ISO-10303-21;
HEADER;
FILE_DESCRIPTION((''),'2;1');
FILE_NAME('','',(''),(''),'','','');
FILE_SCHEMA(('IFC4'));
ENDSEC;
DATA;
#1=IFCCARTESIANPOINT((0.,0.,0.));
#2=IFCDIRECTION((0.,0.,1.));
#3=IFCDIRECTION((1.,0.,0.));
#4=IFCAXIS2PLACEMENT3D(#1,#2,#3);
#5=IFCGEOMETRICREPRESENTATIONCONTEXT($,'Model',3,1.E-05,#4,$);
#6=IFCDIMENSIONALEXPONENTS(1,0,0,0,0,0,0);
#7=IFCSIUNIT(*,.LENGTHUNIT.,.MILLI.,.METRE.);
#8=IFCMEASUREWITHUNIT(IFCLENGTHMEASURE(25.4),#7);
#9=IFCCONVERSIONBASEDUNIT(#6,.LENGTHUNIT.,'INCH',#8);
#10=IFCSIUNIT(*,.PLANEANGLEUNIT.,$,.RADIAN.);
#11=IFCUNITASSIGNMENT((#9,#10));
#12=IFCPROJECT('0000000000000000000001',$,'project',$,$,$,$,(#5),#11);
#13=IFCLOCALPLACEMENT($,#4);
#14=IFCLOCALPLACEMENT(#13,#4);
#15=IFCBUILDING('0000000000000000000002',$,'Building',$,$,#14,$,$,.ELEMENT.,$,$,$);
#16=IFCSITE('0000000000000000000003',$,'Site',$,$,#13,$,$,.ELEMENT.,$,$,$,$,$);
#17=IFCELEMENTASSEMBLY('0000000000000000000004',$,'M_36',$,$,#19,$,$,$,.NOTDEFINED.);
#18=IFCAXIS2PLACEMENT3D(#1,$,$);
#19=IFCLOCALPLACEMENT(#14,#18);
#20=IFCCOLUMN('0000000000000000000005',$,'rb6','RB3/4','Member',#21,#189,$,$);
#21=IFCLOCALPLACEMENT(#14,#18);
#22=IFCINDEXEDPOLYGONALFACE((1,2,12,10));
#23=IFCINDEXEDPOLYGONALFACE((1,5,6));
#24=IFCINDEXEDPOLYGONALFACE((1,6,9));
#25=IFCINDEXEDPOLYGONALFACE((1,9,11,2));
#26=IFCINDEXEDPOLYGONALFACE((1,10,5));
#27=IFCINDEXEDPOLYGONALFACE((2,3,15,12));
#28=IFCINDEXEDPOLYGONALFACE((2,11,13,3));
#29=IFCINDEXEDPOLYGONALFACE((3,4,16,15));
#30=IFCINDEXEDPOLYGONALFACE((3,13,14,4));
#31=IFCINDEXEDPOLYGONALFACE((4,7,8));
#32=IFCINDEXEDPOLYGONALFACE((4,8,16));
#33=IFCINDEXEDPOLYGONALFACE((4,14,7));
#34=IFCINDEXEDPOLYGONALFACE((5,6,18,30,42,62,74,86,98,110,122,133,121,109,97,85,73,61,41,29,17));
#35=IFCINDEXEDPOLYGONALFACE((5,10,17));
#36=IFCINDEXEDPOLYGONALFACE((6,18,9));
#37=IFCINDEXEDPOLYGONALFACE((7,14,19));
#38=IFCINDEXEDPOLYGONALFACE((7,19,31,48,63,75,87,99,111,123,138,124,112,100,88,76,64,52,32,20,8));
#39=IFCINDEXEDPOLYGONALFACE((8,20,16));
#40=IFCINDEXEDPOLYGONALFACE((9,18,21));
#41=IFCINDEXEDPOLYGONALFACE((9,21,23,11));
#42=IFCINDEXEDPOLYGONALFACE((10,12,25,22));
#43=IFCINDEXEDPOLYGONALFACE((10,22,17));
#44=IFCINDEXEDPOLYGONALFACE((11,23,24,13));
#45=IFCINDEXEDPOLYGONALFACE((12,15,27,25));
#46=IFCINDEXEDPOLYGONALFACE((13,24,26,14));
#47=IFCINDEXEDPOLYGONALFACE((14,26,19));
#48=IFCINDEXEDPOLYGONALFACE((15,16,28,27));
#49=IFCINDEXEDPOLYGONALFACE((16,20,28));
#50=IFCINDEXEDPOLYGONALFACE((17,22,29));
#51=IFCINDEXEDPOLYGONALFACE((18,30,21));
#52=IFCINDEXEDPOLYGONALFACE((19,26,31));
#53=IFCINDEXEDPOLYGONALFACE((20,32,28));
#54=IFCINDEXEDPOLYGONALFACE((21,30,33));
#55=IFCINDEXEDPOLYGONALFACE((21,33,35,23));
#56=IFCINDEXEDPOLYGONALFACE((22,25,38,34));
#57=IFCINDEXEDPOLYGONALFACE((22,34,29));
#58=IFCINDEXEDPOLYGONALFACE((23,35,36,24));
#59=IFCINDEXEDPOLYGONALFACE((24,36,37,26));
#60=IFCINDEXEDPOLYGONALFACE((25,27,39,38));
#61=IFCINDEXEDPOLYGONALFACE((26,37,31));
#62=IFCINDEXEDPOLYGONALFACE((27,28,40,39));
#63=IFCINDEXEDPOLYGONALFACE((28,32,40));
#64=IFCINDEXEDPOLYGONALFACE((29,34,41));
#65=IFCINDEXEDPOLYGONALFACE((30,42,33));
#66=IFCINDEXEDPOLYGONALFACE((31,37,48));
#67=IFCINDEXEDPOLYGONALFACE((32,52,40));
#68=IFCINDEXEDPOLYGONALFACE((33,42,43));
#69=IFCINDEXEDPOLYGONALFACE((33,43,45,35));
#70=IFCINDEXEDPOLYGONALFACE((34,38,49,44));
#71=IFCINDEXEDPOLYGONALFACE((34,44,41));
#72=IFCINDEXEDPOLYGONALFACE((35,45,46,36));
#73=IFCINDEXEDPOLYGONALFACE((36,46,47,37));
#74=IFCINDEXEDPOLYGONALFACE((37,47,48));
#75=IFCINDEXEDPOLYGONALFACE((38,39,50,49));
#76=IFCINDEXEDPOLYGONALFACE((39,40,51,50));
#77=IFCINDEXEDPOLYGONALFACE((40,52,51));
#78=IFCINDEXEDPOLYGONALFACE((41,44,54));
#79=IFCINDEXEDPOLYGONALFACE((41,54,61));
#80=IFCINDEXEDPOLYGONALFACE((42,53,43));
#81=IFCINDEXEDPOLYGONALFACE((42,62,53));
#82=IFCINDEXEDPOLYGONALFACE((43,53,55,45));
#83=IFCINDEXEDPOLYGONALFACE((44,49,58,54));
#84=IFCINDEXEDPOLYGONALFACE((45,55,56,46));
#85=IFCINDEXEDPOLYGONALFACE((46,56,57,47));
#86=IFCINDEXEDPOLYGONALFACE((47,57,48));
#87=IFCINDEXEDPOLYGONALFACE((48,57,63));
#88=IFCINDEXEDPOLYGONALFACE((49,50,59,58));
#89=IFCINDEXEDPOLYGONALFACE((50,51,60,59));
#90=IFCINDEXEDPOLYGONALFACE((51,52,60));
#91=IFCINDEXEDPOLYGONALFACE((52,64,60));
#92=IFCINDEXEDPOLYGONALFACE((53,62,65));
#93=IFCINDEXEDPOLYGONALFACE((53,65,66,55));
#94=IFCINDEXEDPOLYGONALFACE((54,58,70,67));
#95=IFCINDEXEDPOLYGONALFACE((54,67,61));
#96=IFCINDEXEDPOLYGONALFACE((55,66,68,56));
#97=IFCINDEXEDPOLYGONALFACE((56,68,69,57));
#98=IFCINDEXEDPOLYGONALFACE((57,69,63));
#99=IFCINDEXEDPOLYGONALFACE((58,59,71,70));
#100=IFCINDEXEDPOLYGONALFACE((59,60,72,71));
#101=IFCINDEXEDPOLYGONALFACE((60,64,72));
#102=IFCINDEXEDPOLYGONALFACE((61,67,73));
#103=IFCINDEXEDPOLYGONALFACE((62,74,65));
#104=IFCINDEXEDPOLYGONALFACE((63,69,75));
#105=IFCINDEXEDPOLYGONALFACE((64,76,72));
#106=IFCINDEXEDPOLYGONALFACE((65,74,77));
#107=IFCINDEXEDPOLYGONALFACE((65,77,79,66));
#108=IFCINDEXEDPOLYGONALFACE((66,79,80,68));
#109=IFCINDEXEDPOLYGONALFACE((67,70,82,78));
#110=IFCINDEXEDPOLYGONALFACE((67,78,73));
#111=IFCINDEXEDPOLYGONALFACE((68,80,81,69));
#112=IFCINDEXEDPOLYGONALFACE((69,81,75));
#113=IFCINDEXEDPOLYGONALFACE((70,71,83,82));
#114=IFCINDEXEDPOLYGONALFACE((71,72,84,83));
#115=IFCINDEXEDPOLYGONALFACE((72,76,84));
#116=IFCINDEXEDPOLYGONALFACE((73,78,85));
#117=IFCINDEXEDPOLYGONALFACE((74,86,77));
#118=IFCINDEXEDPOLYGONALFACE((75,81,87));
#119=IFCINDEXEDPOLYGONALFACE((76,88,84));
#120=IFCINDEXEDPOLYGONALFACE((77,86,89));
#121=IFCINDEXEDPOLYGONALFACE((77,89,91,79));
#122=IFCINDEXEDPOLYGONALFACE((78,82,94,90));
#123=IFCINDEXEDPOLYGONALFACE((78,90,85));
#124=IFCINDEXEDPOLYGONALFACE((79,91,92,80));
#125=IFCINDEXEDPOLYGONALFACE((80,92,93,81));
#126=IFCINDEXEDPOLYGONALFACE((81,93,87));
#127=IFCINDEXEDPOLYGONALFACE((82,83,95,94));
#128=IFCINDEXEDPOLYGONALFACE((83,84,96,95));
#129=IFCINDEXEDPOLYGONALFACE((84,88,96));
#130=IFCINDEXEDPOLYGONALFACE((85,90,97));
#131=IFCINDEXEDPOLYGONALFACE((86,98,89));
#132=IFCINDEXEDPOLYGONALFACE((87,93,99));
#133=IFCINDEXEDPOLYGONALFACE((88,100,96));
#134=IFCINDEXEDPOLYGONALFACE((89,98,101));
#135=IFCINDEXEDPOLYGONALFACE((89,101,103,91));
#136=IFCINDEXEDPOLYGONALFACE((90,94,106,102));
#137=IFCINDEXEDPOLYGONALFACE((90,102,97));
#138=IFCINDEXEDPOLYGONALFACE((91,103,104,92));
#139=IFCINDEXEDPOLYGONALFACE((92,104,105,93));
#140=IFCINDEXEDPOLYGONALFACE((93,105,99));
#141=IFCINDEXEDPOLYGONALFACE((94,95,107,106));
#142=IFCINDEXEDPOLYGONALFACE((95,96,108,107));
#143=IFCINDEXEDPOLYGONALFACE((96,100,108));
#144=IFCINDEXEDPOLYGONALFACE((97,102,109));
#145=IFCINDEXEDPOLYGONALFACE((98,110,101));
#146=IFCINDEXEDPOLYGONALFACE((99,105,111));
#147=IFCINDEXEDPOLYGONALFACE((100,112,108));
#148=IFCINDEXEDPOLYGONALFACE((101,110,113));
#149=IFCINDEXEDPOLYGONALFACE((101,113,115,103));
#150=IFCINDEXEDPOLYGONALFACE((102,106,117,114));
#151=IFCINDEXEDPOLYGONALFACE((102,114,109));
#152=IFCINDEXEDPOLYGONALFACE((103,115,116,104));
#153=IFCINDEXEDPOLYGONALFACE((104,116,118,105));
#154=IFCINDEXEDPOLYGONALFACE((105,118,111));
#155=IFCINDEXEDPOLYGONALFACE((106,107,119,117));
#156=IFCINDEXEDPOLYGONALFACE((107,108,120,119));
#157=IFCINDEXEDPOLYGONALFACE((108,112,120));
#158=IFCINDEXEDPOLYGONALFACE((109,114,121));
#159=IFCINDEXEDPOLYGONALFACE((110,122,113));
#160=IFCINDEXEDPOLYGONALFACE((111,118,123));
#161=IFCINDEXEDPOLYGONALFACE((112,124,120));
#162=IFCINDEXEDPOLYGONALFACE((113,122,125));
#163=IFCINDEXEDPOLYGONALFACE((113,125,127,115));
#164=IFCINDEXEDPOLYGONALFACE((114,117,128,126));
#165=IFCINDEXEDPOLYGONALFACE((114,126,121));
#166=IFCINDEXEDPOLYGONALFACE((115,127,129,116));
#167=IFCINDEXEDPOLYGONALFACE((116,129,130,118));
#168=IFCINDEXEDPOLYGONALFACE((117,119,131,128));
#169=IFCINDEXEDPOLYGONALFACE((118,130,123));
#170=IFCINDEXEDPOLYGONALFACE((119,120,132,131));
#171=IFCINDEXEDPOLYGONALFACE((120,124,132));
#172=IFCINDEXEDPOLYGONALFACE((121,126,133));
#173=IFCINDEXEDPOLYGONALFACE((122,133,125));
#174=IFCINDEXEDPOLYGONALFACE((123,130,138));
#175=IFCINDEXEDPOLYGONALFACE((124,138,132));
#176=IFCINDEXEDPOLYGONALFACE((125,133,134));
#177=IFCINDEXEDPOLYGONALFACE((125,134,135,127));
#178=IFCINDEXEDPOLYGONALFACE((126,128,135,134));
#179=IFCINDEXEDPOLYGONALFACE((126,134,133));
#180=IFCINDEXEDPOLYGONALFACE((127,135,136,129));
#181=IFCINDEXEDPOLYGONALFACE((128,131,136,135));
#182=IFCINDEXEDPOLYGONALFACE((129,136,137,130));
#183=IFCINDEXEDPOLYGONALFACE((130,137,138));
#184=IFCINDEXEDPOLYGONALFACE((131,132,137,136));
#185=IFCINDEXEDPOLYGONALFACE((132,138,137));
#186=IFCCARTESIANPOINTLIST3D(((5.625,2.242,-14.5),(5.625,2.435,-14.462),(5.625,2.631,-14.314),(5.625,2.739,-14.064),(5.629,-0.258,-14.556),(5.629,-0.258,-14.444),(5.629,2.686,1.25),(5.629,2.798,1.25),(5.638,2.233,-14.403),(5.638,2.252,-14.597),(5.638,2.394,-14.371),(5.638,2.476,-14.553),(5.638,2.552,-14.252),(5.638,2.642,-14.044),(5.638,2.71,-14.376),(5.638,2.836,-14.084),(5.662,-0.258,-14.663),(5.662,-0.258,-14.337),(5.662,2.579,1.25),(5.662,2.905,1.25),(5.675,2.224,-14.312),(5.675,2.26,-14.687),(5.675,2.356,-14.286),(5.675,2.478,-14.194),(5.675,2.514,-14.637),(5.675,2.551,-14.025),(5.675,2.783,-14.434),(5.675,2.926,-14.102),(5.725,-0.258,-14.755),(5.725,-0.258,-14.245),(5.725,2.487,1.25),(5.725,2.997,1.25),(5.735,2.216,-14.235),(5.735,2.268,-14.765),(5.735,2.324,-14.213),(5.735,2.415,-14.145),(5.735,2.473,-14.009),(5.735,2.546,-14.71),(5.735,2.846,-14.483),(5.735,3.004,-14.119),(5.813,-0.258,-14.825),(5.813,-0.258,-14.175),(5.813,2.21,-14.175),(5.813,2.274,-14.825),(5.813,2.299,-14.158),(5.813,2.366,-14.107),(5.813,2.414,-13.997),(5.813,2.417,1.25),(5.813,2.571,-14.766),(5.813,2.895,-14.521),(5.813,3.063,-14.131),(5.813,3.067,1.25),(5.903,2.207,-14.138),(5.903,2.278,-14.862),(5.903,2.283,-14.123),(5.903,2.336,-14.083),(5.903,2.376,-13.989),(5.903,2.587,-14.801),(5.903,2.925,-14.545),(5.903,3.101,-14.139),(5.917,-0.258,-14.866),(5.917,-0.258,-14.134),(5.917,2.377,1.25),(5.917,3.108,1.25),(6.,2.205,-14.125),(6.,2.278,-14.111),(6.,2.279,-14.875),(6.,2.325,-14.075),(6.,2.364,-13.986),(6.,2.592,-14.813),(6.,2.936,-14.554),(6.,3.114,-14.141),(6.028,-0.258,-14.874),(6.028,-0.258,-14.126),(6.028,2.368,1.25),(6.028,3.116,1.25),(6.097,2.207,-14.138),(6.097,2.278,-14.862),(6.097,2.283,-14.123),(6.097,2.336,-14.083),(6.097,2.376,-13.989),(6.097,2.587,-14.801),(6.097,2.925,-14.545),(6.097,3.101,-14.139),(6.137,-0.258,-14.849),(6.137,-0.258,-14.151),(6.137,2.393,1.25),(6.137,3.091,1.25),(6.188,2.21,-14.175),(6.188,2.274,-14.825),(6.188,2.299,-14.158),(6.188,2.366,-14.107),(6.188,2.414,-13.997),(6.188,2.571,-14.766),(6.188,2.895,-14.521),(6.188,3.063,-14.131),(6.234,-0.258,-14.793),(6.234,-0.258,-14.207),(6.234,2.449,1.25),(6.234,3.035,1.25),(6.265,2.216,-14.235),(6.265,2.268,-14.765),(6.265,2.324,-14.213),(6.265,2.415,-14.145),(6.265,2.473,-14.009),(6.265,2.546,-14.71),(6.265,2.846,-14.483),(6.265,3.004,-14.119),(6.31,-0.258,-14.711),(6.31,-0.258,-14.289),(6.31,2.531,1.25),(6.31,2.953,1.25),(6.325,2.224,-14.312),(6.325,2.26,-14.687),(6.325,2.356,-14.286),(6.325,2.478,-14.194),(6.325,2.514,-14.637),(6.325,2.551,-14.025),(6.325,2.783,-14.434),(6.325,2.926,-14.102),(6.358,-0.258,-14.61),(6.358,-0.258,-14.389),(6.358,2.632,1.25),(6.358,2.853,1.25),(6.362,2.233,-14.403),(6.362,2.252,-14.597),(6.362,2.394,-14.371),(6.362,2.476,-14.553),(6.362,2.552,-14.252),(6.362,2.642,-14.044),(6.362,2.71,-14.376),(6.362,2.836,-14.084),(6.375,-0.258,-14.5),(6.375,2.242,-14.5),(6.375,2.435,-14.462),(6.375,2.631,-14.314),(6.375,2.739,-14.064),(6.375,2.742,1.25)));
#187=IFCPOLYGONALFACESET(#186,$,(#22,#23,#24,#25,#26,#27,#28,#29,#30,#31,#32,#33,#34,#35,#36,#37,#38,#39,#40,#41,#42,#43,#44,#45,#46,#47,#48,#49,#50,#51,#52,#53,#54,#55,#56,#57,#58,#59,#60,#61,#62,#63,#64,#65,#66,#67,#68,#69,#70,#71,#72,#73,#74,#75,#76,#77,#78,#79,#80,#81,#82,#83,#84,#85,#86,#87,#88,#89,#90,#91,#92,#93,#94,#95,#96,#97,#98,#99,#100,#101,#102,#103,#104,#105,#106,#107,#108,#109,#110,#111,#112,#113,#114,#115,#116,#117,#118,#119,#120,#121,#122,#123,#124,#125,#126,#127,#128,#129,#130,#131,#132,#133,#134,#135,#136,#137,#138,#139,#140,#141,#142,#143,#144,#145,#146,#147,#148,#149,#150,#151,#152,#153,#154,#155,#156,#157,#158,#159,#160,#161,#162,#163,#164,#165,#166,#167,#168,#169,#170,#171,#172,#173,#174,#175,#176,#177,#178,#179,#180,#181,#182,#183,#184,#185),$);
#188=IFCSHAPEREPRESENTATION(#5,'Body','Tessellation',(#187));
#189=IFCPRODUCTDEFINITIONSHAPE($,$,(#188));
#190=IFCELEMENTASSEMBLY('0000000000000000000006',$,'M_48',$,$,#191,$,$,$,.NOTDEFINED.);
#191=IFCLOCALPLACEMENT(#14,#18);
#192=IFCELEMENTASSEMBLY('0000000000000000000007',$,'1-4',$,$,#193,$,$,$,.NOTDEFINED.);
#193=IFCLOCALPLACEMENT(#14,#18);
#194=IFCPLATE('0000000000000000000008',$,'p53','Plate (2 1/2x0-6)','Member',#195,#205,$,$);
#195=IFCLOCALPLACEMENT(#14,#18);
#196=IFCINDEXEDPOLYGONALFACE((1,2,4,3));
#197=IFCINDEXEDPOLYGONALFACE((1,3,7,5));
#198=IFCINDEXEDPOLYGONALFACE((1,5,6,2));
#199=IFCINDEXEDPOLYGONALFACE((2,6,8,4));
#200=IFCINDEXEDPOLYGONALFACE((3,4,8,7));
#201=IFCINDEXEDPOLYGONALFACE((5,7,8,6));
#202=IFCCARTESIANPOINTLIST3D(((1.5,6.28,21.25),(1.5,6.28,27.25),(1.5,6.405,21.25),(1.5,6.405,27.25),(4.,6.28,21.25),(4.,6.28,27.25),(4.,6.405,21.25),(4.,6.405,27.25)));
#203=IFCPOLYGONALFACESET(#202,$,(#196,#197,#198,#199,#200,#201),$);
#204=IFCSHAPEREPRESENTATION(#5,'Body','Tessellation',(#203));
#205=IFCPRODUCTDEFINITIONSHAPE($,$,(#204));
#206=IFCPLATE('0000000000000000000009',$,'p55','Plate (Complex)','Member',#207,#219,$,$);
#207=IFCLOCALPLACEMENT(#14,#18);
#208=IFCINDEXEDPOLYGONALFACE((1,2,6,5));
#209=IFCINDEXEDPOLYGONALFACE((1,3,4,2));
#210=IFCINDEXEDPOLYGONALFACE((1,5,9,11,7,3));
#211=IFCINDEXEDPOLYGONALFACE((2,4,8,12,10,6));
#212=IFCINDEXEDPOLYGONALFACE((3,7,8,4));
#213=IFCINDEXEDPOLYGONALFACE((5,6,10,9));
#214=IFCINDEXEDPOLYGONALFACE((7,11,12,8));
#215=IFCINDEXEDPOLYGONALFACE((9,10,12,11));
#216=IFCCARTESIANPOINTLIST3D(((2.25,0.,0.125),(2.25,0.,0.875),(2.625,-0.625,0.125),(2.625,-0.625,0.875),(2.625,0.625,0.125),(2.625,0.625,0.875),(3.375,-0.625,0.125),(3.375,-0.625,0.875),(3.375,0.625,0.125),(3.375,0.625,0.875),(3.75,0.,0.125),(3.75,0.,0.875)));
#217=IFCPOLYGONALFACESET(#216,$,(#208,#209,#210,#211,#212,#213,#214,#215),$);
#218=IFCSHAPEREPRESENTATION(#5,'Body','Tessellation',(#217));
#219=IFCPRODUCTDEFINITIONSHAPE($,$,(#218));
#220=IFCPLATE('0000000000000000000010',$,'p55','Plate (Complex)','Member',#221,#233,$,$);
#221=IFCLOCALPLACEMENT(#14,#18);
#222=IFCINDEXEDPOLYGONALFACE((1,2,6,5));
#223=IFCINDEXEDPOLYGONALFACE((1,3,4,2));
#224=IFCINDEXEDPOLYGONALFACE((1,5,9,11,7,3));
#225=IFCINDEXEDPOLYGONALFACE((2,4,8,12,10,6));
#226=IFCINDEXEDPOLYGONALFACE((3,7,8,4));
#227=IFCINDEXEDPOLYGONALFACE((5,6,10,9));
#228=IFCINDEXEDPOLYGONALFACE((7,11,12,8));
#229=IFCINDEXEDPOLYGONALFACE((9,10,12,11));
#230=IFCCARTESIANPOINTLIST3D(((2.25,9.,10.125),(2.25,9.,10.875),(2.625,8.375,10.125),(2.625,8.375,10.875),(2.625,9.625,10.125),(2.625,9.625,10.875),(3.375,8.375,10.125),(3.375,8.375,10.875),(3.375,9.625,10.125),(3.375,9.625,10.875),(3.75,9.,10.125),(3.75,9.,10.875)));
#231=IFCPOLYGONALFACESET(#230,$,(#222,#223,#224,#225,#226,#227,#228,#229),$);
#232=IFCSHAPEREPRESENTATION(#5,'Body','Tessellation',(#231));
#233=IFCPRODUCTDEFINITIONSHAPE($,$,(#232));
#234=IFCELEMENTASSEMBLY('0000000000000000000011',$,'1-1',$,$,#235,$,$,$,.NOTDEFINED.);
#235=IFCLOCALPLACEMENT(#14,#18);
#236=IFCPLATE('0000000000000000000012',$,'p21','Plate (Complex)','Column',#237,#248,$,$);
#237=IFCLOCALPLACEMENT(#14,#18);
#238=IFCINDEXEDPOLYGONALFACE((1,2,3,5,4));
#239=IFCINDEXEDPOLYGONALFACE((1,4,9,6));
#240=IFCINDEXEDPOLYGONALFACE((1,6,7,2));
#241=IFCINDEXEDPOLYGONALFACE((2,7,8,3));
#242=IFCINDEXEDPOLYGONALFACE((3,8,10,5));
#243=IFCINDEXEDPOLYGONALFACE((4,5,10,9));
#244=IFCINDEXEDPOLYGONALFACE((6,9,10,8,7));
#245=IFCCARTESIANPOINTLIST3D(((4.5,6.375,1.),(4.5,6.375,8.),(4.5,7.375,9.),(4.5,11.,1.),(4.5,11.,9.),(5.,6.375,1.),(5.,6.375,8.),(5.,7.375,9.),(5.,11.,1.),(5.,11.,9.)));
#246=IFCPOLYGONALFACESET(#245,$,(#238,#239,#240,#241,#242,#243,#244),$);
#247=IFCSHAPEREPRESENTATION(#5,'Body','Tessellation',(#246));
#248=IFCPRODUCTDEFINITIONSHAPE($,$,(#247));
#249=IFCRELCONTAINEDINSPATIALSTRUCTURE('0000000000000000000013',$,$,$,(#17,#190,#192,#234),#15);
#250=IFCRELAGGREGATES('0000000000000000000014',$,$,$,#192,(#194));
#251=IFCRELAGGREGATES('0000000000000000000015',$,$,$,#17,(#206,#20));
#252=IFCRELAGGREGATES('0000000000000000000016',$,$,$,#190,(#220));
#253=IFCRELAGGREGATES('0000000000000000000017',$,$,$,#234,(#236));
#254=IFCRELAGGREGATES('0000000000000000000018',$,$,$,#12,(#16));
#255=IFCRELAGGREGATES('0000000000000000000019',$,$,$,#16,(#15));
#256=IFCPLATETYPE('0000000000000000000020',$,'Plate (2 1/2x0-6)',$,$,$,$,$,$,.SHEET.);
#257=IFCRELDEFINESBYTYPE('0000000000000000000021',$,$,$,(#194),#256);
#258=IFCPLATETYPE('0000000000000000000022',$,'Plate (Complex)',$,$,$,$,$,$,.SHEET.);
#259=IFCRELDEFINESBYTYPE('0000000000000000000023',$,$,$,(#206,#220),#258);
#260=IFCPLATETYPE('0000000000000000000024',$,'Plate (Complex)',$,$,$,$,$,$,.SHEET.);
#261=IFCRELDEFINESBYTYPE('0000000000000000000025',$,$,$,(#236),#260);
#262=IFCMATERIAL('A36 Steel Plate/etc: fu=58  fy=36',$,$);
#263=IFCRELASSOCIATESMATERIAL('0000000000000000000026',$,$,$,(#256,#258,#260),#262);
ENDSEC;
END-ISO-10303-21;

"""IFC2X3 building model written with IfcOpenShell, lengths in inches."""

from ifc_helpers import new_model, entity, si_unit, converted_unit, frame, origin_with_axes, place, context, project, spatial, polyline, outline, extrude, source, transform, mapped, material, type_object, type_shapes, element, aggregate, save


model = new_model("IFC2X3")

# Units and contexts
model_context = context("Model", 3, precision=1e-05, world=origin_with_axes())
ifc_project = project(units=[converted_unit("LENGTHUNIT", "INCH", entity("IfcLengthMeasure", 25.4), si_unit("LENGTHUNIT", "METRE", prefix="MILLI"), dimensions=[1, 0, 0, 0, 0, 0, 0]), si_unit("PLANEANGLEUNIT", "RADIAN")], contexts=[model_context])

# Site, building
site_placement = place(None, origin_with_axes())
site = spatial("IfcSite", under=ifc_project, at=site_placement, Name="Site", CompositionType="ELEMENT")
building_placement = place(site_placement, origin_with_axes())
building = spatial("IfcBuilding", under=site, at=building_placement, Name="Building", CompositionType="ELEMENT")

# Element assemblies, column
assembly_1_placement = place(building_placement, frame((3.0, 0.0, -22.668), z_axis=(0.0, -1.0, 0.0), x_axis=(0.0, 0.0, 1.0)))
assembly_1 = element("IfcElementAssembly", 1, at=assembly_1_placement, inside=building, Name="M_36", PredefinedType="NOTDEFINED")
column_1_placement = place(assembly_1_placement, frame((8.44, -3.0, 0.258), z_axis=(0.0, -1.0, 0.0), x_axis=(-1.0, 0.0, 0.0)))
cartesian_point_1 = entity("IfcCartesianPoint", [0.0, 0.0, 0.0])
ifc_direction_1 = entity("IfcDirection", [0.0, 0.0, 1.0])
ifc_direction_2 = entity("IfcDirection", [1.0, 0.0, 0.0])
column_1 = element("IfcColumn", 2, at=column_1_placement, Name="rb6", Description="RB3/4", ObjectType="Member", context=model_context, shape_type="SweptSolid", body=[
    entity("IfcSurfaceCurveSweptAreaSolid", entity("IfcCircleProfileDef", "AREA", None, entity("IfcAxis2Placement2D", entity("IfcCartesianPoint", [0.0, 0.0]), entity("IfcDirection", [1.0, 0.0])), 0.375), entity("IfcAxis2Placement3D", cartesian_point_1, ifc_direction_1, ifc_direction_2), entity("IfcPolyline", [entity("IfcCartesianPoint", [0.272, 0.0]), entity("IfcCartesianPoint", [0.272, 2.5]), entity("IfcCartesianPoint", [0.234, 2.693]), entity("IfcCartesianPoint", [0.086, 2.888]), entity("IfcCartesianPoint", [-0.164, 2.996]), entity("IfcCartesianPoint", [-15.478, 3.0])]), 0.0, 1.0, entity("IfcPlane", entity("IfcAxis2Placement3D", cartesian_point_1, ifc_direction_1, ifc_direction_2))),
])
assembly_2_placement = place(building_placement, frame((3.0, 9.0, -22.668), z_axis=(0.0, -1.0, 0.0), x_axis=(0.0, 0.0, 1.0)))
assembly_2 = element("IfcElementAssembly", 3, at=assembly_2_placement, inside=building, Name="M_48", PredefinedType="NOTDEFINED")

# Element assembly, plate
assembly_3_placement = place(building_placement, frame((1.5, 6.28, 21.25), z_axis=(-1.0, 0.0, 0.0), x_axis=(0.0, -1.0, 0.0)))
assembly_3 = element("IfcElementAssembly", 4, at=assembly_3_placement, inside=building, Name="1-4", PredefinedType="NOTDEFINED")
ifc_material = material(Name="A36 Steel Plate/etc: fu=58  fy=36")
plate_type_1 = type_object("IfcPlateType", Name="Plate (2 1/2x0-6)", PredefinedType="SHEET", material=ifc_material)
shared_shape_1 = source(origin_with_axes(), model_context, "Body", "SweptSolid", [
    extrude(outline(polyline([(0.0, -2.5), (-6.0, -2.5), (-6.0, 0.0), (0.0, 0.0), (0.0, -2.5)])), frame((-0.062, 0.0, 0.0), z_axis=(1.0, 0.0, 0.0), x_axis=(0.0, 1.0, 0.0)), (0.0, 0.0, 1.0), 0.125),
])
type_shapes(plate_type_1, [shared_shape_1])
plate_1_placement = place(assembly_3_placement, frame((-0.062, 0.0, 0.0), z_axis=(0.0, 0.0, 1.0), x_axis=(-1.0, 0.0, 0.0)))
plate_1 = element("IfcPlate", 5, at=plate_1_placement, type_object=plate_type_1, Name="p53", Description="Plate (2 1/2x0-6)", ObjectType="Member", context=model_context, shape_type="MappedRepresentation", body=[
    mapped(shared_shape_1, transform((0.0, 0.0, 0.0), scale=1.0)),
])
aggregate(assembly_3, [plate_1])

# Plates
plate_type_2 = type_object("IfcPlateType", Name="Plate (Complex)", PredefinedType="SHEET", material=ifc_material)
shared_shape_2 = source(origin_with_axes(), model_context, "Body", "SweptSolid", [
    extrude(outline(polyline([(0.0, -1.125), (-0.625, -1.5), (-1.25, -1.125), (-1.25, -0.375), (-0.625, 0.0), (0.0, -0.375), (0.0, -1.125)])), frame((-0.375, 0.0, 0.0), z_axis=(1.0, 0.0, 0.0), x_axis=(0.0, 1.0, 0.0)), (0.0, 0.0, 1.0), 0.75),
])
type_shapes(plate_type_2, [shared_shape_2])
plate_2_placement = place(assembly_1_placement, frame((23.168, 0.75, -0.625), z_axis=(0.0, 1.0, 0.0), x_axis=(1.0, 0.0, 0.0)))
plate_2 = element("IfcPlate", 6, at=plate_2_placement, type_object=plate_type_2, Name="p55", Description="Plate (Complex)", ObjectType="Member", context=model_context, shape_type="MappedRepresentation", body=[
    mapped(shared_shape_2, transform((0.0, 0.0, 0.0), scale=1.0)),
])
aggregate(assembly_1, [plate_2, column_1])
plate_3_placement = place(assembly_2_placement, frame((33.168, 0.75, -0.625), z_axis=(0.0, 1.0, 0.0), x_axis=(1.0, 0.0, 0.0)))
plate_3 = element("IfcPlate", 7, at=plate_3_placement, type_object=plate_type_2, Name="p55", Description="Plate (Complex)", ObjectType="Member", context=model_context, shape_type="MappedRepresentation", body=[
    mapped(shared_shape_2, transform((0.0, 0.0, 0.0), scale=1.0)),
])
aggregate(assembly_2, [plate_3])

# Element assembly, plate
assembly_4_placement = place(building_placement, frame((0.0, 0.0, -1.5), z_axis=(0.0, -1.0, 0.0), x_axis=(0.0, 0.0, 1.0)))
assembly_4 = element("IfcElementAssembly", 8, at=assembly_4_placement, inside=building, Name="1-1", PredefinedType="NOTDEFINED")
plate_type_3 = type_object("IfcPlateType", Name="Plate (Complex)", PredefinedType="SHEET", material=ifc_material)
shared_shape_3 = source(origin_with_axes(), model_context, "Body", "SweptSolid", [
    extrude(outline(polyline([(0.0, -8.0), (-3.625, -8.0), (-4.625, -7.0), (-4.625, 0.0), (0.0, 0.0), (0.0, -8.0)])), frame((-0.25, 0.0, 0.0), z_axis=(1.0, 0.0, 0.0), x_axis=(0.0, 1.0, 0.0)), (0.0, 0.0, 1.0), 0.5),
])
type_shapes(plate_type_3, [shared_shape_3])
plate_4_placement = place(assembly_4_placement, frame((2.5, -4.75, -11.0), z_axis=(-1.0, 0.0, 0.0), x_axis=(0.0, 1.0, 0.0)))
plate_4 = element("IfcPlate", 9, at=plate_4_placement, type_object=plate_type_3, Name="p21", Description="Plate (Complex)", ObjectType="Column", context=model_context, shape_type="MappedRepresentation", body=[
    mapped(shared_shape_3, transform((0.0, 0.0, 0.0), scale=1.0)),
])
aggregate(assembly_4, [plate_4])

save(model, "model.ifc")
